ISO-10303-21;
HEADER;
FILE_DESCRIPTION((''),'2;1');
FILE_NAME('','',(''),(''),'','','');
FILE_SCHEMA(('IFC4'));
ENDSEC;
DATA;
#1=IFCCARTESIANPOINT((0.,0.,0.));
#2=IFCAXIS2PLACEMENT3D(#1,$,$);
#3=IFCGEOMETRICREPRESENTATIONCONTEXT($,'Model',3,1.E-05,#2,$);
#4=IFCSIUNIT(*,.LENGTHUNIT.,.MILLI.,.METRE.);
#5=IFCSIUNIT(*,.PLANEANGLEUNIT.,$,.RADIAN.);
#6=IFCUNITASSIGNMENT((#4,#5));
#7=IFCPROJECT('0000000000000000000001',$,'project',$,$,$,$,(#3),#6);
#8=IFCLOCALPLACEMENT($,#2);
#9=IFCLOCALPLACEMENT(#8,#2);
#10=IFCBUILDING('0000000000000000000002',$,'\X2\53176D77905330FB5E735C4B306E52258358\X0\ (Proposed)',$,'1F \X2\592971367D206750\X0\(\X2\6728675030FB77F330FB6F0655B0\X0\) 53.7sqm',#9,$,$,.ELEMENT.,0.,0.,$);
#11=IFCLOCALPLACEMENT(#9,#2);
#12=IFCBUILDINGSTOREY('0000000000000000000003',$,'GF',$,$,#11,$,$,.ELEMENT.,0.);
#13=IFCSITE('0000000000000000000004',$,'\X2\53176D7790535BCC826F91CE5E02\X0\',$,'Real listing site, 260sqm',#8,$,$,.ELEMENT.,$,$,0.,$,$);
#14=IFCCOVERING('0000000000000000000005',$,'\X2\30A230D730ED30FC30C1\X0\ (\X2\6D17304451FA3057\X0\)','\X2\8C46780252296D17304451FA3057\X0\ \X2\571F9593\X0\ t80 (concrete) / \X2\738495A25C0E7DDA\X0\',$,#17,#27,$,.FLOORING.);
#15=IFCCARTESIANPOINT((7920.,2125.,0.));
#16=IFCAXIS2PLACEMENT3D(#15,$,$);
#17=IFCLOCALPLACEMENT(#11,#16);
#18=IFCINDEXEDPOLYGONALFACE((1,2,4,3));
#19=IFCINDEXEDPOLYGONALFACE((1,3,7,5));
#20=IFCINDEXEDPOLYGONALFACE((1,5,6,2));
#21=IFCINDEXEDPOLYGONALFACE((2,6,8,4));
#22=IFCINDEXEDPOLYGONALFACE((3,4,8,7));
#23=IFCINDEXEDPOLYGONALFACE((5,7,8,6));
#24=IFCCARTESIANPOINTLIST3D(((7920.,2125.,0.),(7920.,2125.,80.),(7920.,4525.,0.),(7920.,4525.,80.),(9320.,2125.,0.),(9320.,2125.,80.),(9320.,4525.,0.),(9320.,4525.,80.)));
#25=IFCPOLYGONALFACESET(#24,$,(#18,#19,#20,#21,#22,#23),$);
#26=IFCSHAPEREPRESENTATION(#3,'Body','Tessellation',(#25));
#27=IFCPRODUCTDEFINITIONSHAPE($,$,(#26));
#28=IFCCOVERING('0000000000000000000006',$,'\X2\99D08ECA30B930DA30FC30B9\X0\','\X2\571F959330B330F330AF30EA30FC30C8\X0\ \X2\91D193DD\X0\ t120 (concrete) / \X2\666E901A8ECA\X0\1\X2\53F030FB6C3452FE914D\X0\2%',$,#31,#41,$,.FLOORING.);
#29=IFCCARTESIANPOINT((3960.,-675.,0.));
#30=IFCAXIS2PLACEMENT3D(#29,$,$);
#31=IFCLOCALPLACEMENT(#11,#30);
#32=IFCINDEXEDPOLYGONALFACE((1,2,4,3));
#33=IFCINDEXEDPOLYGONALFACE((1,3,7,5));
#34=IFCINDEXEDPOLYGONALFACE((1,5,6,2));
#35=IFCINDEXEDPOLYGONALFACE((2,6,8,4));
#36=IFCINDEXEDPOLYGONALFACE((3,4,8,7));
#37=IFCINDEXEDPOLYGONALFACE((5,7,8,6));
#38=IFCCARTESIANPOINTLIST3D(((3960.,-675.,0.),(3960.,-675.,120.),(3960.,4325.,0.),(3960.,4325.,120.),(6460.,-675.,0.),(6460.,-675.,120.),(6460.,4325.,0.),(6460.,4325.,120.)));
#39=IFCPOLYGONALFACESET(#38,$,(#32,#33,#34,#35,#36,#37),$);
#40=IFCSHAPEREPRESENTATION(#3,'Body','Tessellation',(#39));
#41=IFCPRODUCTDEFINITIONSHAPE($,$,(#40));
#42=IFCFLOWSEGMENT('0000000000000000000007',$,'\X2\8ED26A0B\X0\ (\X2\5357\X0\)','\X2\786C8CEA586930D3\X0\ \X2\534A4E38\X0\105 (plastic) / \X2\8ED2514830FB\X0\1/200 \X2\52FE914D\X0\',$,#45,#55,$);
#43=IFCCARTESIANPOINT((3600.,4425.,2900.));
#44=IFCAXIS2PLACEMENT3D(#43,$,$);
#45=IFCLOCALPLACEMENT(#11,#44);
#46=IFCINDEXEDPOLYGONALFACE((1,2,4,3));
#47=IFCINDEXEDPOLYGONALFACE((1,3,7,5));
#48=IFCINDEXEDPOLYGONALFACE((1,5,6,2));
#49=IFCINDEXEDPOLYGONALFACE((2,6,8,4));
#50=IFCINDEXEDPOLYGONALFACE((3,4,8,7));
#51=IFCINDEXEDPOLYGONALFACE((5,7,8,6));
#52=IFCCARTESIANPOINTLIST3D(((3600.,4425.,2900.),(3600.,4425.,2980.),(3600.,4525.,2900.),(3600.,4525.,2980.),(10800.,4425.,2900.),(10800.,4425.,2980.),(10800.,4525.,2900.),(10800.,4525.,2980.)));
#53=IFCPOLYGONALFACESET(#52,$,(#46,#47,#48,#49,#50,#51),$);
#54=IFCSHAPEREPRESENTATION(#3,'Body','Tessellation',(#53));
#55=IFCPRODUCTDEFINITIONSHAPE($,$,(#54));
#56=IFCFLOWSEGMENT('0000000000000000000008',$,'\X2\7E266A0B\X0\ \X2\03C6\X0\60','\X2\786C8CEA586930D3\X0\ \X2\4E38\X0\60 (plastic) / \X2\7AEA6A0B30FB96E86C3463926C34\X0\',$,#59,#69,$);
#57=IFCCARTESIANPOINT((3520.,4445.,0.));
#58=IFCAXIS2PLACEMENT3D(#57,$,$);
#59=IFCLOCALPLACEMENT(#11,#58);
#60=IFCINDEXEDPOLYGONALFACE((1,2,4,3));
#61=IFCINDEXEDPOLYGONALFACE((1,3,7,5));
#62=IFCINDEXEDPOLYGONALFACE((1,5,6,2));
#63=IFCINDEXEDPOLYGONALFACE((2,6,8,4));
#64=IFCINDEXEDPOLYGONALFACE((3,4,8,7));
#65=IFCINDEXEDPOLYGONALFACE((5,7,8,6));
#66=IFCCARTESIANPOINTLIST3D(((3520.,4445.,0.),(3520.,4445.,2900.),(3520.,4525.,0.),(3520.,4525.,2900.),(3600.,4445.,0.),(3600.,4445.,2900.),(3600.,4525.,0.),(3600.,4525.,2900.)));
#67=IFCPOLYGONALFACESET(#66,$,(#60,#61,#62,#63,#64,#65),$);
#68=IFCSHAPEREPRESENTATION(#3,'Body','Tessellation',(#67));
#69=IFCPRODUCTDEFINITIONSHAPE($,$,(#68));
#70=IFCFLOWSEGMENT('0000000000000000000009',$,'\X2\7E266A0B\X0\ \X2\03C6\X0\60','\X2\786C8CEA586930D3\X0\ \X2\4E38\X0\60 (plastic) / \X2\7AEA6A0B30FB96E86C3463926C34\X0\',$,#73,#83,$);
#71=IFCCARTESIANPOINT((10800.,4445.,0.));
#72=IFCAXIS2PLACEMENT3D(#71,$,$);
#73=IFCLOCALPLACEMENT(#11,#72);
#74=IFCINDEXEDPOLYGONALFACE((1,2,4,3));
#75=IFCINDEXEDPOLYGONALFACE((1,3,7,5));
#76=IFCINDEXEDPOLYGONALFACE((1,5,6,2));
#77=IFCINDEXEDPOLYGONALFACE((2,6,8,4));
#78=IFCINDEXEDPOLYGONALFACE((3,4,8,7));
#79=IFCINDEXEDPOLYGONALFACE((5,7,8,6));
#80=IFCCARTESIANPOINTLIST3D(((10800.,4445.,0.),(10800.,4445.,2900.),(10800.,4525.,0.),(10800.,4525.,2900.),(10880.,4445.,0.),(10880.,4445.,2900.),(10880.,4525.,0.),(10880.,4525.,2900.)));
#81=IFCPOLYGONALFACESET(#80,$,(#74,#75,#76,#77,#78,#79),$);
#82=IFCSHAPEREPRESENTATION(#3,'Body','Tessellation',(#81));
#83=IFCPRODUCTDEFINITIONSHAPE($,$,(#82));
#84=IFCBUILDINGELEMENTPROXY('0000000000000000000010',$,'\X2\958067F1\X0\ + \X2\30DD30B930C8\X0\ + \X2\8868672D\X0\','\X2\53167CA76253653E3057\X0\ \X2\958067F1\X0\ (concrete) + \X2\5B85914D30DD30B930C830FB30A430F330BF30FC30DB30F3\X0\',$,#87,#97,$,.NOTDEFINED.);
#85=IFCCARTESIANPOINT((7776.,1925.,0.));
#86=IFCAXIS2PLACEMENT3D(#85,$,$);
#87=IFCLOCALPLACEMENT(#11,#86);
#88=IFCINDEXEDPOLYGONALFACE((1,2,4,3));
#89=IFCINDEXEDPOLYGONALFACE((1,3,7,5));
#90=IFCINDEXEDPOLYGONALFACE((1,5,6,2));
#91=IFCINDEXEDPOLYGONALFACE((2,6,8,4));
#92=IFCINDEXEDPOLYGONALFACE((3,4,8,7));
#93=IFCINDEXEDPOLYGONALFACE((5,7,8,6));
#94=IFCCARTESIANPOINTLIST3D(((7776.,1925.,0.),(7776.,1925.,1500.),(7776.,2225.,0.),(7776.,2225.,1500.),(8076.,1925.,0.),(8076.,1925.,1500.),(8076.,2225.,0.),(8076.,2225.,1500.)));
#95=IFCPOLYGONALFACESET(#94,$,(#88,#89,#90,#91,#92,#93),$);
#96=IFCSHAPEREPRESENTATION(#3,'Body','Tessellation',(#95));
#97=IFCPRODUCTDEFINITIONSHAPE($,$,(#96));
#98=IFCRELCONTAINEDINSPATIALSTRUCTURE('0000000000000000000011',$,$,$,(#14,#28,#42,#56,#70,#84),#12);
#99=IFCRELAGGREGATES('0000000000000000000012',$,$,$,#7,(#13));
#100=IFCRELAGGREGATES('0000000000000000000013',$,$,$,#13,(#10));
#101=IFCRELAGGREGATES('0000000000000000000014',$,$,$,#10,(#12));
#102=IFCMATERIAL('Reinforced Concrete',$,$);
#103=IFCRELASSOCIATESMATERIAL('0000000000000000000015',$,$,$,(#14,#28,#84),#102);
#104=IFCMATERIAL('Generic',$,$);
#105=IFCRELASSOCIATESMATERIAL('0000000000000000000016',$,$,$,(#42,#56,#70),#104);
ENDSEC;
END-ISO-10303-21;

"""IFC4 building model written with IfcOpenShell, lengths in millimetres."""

from ifc_helpers import new_model, si_unit, frame, frame_2d, origin, place, context, project, spatial, rectangle, extrude, material, element, save


model = new_model("IFC4")

# Units and contexts
model_context = context("Model", 3, precision=1e-05, world=origin())
ifc_project = project(units=[si_unit("LENGTHUNIT", "METRE", prefix="MILLI"), si_unit("PLANEANGLEUNIT", "RADIAN")], contexts=[model_context])

# Site, building, storey
site_placement = place(None, origin())
site = spatial("IfcSite", under=ifc_project, at=site_placement, Name="北海道富良野市", ObjectType="Real listing site, 260sqm", CompositionType="ELEMENT", RefElevation=0.0)
building_placement = place(site_placement, origin())
building = spatial("IfcBuilding", under=site, at=building_placement, Name="北海道・平屋の別荘 (Proposed)", ObjectType="1F 天然素材(木材・石・漆喰) 53.7sqm", CompositionType="ELEMENT", ElevationOfRefHeight=0.0, ElevationOfTerrain=0.0)
storey_placement = place(building_placement, origin())
storey = spatial("IfcBuildingStorey", under=building, at=storey_placement, Name="GF", CompositionType="ELEMENT", Elevation=0.0)

# Shared definitions
ifc_material_1 = material(Name="Reinforced Concrete")

# Coverings
ifc_material_2 = material(Name="Generic")
covering_1_placement = place(storey_placement, frame((7920.0, 2125.0, 0.0)))
element("IfcCovering", 1, at=covering_1_placement, inside=storey, material=ifc_material_1, Name="アプローチ (洗い出し)", Description="豆砂利洗い出し 土間 t80 (concrete) / 玄関導線", PredefinedType="FLOORING", context=model_context, shape_type="SweptSolid", body=[
    extrude(rectangle(XDim=1400.0, YDim=2400.0, at=frame_2d((700.0, 1200.0))), frame((7920.0, 2125.0, 0.0)), (0.0, 0.0, 1.0), 80.0),
])
covering_2_placement = place(storey_placement, frame((3960.0, -675.0, 0.0)))
element("IfcCovering", 2, at=covering_2_placement, inside=storey, material=ifc_material_1, Name="駐車スペース", Description="土間コンクリート 金鏝 t120 (concrete) / 普通車1台・水勾配2%", PredefinedType="FLOORING", context=model_context, shape_type="SweptSolid", body=[
    extrude(rectangle(XDim=2500.0, YDim=5000.0, at=frame_2d((1250.0, 2500.0))), frame((3960.0, -675.0, 0.0)), (0.0, 0.0, 1.0), 120.0),
])

# Flow segments
flow_segment_1_placement = place(storey_placement, frame((3600.0, 4425.0, 2900.0)))
element("IfcFlowSegment", 3, at=flow_segment_1_placement, inside=storey, material=ifc_material_2, Name="軒樋 (南)", Description="硬質塩ビ 半丸105 (plastic) / 軒先・1/200 勾配", context=model_context, shape_type="SweptSolid", body=[
    extrude(rectangle(XDim=7200.0, YDim=100.0, at=frame_2d((3600.0, 50.0))), frame((3600.0, 4425.0, 2900.0)), (0.0, 0.0, 1.0), 80.0),
])
flow_segment_2_placement = place(storey_placement, frame((3520.0, 4445.0, 0.0)))
element("IfcFlowSegment", 4, at=flow_segment_2_placement, inside=storey, material=ifc_material_2, Name="縦樋 φ60", Description="硬質塩ビ 丸60 (plastic) / 竪樋・雨水排水", context=model_context, shape_type="SweptSolid", body=[
    extrude(rectangle(XDim=80.0, YDim=80.0, at=frame_2d((40.0, 40.0))), frame((3520.0, 4445.0, 0.0)), (0.0, 0.0, 1.0), 2900.0),
])
flow_segment_3_placement = place(storey_placement, frame((10800.0, 4445.0, 0.0)))
element("IfcFlowSegment", 5, at=flow_segment_3_placement, inside=storey, material=ifc_material_2, Name="縦樋 φ60", Description="硬質塩ビ 丸60 (plastic) / 竪樋・雨水排水", context=model_context, shape_type="SweptSolid", body=[
    extrude(rectangle(XDim=80.0, YDim=80.0, at=frame_2d((40.0, 40.0))), frame((10800.0, 4445.0, 0.0)), (0.0, 0.0, 1.0), 2900.0),
])

# Building element proxy
proxy_placement = place(storey_placement, frame((7776.0, 1925.0, 0.0)))
element("IfcBuildingElementProxy", 6, at=proxy_placement, inside=storey, material=ifc_material_1, Name="門柱 + ポスト + 表札", Description="化粧打放し 門柱 (concrete) + 宅配ポスト・インターホン", PredefinedType="NOTDEFINED", context=model_context, shape_type="SweptSolid", body=[
    extrude(rectangle(XDim=300.0, YDim=300.0, at=frame_2d((150.0, 150.0))), frame((7776.0, 1925.0, 0.0)), (0.0, 0.0, 1.0), 1500.0),
])

save(model, "model.ifc")
